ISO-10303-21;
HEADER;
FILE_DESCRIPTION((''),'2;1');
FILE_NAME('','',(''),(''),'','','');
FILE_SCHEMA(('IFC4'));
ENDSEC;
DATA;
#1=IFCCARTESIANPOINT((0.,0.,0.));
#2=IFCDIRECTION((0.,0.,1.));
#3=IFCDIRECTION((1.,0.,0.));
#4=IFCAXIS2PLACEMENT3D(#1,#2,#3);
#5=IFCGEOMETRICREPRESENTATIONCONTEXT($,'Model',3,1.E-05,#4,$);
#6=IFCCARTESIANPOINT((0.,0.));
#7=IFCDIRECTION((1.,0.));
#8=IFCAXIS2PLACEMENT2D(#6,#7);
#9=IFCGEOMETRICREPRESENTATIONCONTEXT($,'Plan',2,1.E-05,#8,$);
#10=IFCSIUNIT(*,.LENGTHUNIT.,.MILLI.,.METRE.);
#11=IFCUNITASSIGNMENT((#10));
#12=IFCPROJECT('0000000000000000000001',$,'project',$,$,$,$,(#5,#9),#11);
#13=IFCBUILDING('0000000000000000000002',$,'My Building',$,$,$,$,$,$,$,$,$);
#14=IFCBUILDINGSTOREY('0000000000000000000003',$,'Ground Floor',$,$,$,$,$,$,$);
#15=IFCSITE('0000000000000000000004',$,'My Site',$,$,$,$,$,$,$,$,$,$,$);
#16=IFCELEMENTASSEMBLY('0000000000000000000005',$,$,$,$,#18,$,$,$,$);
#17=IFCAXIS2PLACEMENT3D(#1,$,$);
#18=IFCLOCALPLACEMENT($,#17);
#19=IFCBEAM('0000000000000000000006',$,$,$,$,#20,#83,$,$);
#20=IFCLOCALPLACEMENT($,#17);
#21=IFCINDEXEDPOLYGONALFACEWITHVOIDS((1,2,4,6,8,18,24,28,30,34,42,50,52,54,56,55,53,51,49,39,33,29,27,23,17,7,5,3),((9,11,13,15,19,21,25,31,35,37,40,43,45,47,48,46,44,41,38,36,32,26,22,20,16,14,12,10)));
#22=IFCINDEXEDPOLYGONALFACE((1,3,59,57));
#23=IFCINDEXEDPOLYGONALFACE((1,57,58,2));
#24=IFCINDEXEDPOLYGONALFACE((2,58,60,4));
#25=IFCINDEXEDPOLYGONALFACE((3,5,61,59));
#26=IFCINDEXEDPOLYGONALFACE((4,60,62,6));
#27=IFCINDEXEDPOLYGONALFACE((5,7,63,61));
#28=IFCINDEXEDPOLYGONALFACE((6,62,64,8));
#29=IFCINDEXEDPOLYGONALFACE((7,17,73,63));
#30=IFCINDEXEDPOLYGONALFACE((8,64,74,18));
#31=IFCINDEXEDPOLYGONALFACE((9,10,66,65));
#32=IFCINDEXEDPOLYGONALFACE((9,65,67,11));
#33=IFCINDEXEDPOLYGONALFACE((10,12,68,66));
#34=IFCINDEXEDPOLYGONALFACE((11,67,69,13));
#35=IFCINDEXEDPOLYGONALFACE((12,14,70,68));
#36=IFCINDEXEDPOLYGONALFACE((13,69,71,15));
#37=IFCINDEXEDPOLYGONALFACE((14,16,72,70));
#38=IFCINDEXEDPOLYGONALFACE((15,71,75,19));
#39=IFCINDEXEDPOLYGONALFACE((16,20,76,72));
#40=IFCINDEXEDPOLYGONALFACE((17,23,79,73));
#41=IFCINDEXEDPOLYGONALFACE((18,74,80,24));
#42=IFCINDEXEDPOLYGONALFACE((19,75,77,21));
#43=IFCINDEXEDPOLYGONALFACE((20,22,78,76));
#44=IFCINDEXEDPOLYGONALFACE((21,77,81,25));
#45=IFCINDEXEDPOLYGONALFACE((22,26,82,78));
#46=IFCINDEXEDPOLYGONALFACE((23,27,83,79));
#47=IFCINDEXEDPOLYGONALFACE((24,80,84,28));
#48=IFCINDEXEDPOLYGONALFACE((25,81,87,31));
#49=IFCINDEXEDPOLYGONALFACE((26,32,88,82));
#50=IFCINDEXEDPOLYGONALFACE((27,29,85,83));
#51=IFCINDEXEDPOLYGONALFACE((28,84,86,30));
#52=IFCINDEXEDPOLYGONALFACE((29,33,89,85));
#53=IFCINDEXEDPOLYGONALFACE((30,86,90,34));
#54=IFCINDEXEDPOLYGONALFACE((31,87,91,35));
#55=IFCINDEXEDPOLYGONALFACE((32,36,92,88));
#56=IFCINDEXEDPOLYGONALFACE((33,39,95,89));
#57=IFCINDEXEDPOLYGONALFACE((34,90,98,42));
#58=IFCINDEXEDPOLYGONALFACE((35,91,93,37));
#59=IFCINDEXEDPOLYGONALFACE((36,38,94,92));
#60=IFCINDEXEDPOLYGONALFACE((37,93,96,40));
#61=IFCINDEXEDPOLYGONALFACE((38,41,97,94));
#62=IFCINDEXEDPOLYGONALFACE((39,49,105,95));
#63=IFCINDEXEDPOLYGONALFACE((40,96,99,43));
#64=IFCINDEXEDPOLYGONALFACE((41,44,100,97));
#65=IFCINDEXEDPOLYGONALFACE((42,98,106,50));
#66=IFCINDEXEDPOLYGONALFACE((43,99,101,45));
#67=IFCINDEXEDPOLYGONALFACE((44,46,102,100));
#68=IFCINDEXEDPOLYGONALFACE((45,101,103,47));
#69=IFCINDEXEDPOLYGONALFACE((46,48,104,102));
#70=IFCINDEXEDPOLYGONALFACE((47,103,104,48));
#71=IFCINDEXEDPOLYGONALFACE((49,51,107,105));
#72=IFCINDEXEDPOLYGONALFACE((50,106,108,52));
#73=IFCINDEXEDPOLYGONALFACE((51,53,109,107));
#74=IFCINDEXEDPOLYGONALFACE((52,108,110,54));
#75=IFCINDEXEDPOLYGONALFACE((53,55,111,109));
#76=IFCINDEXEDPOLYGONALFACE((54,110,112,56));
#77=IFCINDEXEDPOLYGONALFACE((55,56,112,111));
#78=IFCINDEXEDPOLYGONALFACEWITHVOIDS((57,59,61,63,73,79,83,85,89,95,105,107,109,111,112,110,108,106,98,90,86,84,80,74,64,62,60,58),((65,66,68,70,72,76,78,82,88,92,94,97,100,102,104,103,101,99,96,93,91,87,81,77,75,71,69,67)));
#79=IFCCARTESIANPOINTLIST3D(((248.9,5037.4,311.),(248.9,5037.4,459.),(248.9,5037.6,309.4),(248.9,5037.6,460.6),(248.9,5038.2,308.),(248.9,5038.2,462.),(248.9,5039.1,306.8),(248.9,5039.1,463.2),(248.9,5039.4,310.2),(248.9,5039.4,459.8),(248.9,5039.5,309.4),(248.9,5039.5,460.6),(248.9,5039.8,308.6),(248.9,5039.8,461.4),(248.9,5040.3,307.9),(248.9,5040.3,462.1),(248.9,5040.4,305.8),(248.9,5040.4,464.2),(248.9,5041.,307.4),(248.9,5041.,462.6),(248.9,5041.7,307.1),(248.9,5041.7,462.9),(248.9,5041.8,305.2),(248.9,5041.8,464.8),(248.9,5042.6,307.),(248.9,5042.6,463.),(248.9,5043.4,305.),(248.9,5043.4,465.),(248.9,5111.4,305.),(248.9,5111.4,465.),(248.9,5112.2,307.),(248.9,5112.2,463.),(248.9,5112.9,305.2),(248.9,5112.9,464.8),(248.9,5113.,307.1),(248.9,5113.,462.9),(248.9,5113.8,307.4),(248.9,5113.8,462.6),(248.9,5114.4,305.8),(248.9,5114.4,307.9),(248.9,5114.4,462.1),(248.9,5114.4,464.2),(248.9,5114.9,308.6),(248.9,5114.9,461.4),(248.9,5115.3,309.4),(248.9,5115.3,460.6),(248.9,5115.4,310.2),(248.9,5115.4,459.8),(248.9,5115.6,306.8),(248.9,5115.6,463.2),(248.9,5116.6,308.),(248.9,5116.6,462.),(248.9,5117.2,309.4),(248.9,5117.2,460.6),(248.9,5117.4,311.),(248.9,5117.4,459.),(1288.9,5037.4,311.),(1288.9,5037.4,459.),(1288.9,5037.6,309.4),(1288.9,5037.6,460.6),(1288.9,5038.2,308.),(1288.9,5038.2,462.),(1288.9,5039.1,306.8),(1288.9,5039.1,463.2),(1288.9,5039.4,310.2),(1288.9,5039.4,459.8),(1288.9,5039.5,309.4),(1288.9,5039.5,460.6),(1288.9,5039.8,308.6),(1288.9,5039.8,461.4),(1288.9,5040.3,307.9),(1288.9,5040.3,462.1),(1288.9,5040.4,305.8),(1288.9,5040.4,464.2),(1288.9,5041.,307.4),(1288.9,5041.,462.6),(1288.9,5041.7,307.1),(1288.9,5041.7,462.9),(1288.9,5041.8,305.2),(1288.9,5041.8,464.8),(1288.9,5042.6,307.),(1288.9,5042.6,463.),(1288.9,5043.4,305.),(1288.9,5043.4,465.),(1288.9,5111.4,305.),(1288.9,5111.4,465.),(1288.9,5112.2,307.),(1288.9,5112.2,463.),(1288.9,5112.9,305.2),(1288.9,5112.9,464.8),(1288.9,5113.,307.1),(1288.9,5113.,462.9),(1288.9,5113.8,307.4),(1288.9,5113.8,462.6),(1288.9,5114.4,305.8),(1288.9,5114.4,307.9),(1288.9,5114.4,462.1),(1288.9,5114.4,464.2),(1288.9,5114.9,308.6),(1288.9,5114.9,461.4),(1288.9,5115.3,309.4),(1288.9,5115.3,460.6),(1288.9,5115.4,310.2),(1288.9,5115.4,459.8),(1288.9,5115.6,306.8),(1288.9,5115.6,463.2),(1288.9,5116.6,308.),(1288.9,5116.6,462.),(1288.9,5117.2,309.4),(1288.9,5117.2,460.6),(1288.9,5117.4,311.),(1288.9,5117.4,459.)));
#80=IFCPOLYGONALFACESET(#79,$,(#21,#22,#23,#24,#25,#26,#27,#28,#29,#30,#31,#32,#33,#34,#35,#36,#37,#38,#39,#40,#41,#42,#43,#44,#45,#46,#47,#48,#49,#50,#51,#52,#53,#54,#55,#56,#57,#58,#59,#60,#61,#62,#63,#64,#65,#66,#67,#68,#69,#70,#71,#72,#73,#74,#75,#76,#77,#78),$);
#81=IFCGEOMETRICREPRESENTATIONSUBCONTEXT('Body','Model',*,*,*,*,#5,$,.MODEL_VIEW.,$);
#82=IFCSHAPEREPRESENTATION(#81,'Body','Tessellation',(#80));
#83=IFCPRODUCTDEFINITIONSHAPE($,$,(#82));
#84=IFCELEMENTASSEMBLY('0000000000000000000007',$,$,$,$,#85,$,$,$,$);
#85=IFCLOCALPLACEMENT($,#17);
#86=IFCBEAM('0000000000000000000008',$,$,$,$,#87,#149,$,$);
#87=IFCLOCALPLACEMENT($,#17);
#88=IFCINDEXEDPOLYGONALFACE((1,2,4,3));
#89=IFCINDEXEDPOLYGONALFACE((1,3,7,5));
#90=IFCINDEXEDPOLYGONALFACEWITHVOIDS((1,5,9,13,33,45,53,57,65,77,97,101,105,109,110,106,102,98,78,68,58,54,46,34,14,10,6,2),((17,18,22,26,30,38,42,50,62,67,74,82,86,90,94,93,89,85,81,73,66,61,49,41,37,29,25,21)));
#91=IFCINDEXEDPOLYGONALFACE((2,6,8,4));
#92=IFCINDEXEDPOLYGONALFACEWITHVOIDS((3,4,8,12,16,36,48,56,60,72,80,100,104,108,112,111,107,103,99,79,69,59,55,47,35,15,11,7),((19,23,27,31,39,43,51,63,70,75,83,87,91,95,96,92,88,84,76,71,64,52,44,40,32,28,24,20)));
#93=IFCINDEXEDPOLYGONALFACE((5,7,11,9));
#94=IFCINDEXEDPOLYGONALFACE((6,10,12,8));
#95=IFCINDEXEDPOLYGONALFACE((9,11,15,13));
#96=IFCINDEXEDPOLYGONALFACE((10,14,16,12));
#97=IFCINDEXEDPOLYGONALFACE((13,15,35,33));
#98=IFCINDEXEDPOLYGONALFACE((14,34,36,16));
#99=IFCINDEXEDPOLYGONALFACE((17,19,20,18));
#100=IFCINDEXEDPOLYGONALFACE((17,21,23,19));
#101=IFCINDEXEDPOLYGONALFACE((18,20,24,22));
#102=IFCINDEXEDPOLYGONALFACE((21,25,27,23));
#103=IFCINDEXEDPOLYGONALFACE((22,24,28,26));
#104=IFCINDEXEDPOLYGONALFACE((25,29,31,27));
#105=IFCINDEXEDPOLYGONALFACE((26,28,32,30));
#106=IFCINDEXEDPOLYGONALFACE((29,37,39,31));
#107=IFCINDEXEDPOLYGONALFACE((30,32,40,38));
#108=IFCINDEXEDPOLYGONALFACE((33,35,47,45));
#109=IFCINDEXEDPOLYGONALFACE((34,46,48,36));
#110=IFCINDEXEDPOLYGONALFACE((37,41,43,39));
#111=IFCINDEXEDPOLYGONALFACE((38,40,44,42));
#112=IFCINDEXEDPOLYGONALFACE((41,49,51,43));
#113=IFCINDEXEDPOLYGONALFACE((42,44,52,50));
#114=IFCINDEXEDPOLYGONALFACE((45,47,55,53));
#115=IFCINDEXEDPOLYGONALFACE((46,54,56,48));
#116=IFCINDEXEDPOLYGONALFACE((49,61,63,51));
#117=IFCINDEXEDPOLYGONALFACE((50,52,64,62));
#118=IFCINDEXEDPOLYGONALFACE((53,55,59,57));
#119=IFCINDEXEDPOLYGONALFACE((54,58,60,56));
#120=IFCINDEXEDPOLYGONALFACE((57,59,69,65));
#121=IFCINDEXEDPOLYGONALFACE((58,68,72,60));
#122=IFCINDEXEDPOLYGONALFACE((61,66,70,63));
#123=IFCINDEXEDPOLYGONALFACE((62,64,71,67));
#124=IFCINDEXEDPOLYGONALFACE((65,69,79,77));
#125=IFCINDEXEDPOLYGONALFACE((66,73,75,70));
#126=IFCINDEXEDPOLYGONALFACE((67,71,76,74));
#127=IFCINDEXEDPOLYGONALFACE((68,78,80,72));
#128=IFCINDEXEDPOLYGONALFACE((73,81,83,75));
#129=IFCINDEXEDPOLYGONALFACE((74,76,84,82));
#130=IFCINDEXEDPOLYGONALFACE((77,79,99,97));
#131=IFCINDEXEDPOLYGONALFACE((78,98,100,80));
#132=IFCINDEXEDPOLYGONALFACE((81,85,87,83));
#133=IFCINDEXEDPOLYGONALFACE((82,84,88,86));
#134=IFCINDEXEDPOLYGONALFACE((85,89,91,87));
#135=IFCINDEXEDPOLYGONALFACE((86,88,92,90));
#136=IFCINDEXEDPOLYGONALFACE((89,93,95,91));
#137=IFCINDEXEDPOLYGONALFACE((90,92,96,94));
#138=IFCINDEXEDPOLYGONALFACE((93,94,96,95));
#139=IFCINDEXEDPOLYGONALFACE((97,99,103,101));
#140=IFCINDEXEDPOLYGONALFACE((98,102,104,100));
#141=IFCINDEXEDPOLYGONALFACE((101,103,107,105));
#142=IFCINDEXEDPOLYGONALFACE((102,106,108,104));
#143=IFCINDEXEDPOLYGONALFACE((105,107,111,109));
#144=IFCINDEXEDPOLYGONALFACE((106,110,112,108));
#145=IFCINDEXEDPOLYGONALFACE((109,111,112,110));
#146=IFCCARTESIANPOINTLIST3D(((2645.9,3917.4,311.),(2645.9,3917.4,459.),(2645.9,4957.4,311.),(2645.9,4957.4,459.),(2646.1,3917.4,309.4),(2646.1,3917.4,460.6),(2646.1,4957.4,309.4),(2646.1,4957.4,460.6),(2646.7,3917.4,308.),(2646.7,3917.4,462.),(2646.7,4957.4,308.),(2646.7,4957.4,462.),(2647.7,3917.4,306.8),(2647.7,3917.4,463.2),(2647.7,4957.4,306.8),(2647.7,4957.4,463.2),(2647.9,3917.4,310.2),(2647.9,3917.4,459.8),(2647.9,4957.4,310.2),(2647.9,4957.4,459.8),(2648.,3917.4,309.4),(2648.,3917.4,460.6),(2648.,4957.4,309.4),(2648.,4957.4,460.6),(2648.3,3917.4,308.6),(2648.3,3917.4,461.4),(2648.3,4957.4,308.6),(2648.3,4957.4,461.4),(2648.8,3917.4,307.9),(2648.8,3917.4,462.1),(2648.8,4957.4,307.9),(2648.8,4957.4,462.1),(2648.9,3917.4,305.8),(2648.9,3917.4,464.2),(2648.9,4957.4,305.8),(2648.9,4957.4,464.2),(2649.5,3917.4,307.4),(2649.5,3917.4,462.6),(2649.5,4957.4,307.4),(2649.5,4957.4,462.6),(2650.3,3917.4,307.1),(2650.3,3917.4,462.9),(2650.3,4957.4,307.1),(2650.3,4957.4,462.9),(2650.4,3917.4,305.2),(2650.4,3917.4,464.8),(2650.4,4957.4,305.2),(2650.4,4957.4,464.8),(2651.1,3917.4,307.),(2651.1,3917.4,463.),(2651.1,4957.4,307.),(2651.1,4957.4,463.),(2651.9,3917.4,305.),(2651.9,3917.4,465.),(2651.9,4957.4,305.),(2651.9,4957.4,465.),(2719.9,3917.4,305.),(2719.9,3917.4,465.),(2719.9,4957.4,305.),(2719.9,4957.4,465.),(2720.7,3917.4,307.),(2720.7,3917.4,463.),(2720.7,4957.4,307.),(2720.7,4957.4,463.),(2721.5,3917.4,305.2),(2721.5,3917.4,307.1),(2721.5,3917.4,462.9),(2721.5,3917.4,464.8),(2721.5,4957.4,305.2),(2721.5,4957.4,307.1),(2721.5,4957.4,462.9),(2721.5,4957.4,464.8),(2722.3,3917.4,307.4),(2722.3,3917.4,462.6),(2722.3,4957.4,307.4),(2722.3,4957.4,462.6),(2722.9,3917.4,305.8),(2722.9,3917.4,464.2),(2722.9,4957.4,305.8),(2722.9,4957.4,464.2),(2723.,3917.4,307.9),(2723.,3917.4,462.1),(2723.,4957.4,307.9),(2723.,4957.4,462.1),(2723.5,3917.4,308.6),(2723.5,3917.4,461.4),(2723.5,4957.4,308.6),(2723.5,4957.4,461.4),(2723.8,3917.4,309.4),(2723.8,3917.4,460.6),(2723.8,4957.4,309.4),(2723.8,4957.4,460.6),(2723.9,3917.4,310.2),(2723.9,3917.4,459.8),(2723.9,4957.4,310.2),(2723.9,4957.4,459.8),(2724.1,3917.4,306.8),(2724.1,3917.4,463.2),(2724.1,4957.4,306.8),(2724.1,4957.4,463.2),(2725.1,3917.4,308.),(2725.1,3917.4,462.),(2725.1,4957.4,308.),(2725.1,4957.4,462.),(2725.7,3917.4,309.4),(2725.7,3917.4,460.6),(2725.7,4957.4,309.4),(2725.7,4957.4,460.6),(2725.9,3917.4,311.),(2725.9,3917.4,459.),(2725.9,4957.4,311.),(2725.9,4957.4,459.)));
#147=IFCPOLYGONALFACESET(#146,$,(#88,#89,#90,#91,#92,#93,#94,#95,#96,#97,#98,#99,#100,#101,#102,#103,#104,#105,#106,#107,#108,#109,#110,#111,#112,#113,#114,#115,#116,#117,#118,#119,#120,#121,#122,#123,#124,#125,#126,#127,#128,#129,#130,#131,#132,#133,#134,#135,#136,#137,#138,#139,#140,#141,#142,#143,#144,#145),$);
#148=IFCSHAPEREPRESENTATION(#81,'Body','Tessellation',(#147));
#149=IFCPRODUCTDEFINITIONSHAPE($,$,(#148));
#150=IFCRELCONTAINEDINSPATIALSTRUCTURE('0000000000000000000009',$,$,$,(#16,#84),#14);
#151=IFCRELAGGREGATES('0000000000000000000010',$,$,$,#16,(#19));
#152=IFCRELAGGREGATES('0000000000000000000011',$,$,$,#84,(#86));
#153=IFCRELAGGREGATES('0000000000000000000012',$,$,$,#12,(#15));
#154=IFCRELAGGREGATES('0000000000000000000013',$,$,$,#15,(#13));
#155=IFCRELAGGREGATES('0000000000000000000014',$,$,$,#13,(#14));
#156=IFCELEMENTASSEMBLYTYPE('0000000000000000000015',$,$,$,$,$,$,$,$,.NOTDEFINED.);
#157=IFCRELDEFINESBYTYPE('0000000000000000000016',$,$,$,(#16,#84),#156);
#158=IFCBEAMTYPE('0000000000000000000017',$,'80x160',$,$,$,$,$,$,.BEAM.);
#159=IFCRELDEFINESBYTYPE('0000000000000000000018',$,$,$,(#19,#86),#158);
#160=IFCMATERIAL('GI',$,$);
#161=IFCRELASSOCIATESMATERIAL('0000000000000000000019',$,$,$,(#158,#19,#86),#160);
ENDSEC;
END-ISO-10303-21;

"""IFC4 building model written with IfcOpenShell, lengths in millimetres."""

from ifc_helpers import new_model, si_unit, frame, origin_with_axes, origin_2d_with_axis, place, context, subcontext, project, spatial, hollow_rectangle, extrude, material, material_profile, profile_set, profile_usage, type_object, element, aggregate, save


model = new_model("IFC4")

# Units and contexts
model_context = context("Model", 3, precision=1e-05, world=origin_with_axes())
plan_context = context("Plan", 2, precision=1e-05, world=origin_2d_with_axis())
body_context = subcontext(model_context, "Body", "Model", "MODEL_VIEW")
ifc_project = project(units=[si_unit("LENGTHUNIT", "METRE", prefix="MILLI")], contexts=[model_context, plan_context])

# Site, building, storey
site = spatial("IfcSite", under=ifc_project, Name="My Site")
building = spatial("IfcBuilding", under=site, Name="My Building")
storey = spatial("IfcBuildingStorey", under=building, Name="Ground Floor")

# Shared definitions
ifc_material = material(Name="GI")

# Element assemblies, beams
element_assembly_type_1 = type_object("IfcElementAssemblyType", PredefinedType="NOTDEFINED")
ifc_material_profile_1 = material_profile(ifc_material, hollow_rectangle(XDim=80.0, YDim=160.0, WallThickness=2.0, InnerFilletRadius=3.2, OuterFilletRadius=6.0))
ifc_profile_set_1 = profile_set([ifc_material_profile_1], Name="80x160 GI Rectangular Hollow")
beam_type = type_object("IfcBeamType", Name="80x160", PredefinedType="BEAM", material=ifc_profile_set_1)
assembly_1_placement = place(None, frame((168.9, 5077.4, 385.0), z_axis=(1.0, 0.0, 0.0), x_axis=(0.0, 1.0, 0.0)))
assembly_1 = element("IfcElementAssembly", 1, at=assembly_1_placement, inside=storey, type_object=element_assembly_type_1)
ifc_profile_usage_1 = profile_usage(ifc_profile_set_1)
beam_1_placement = place(assembly_1_placement, frame((0.0, 0.0, 80.0), z_axis=(0.0, 0.0, 1.0), x_axis=(1.0, 0.0, 0.0)))
beam_1 = element("IfcBeam", 2, at=beam_1_placement, type_object=beam_type, material=ifc_profile_usage_1, context=body_context, shape_type="SweptSolid", body=[
    extrude(hollow_rectangle(XDim=80.0, YDim=160.0, WallThickness=2.0, InnerFilletRadius=3.2, OuterFilletRadius=6.0), origin_with_axes(), (0.0, 0.0, 1.0), 1040.0),
])
aggregate(assembly_1, [beam_1])
assembly_2_placement = place(None, frame((2685.9, 3837.4, 385.0), z_axis=(0.0, 1.0, 0.0), x_axis=(1.0, 0.0, 0.0)))
assembly_2 = element("IfcElementAssembly", 3, at=assembly_2_placement, inside=storey, type_object=element_assembly_type_1)
ifc_profile_usage_2 = profile_usage(ifc_profile_set_1)
beam_2_placement = place(assembly_2_placement, frame((0.0, 0.0, 80.0), z_axis=(0.0, 0.0, 1.0), x_axis=(1.0, 0.0, 0.0)))
beam_2 = element("IfcBeam", 4, at=beam_2_placement, type_object=beam_type, material=ifc_profile_usage_2, context=body_context, shape_type="SweptSolid", body=[
    extrude(hollow_rectangle(XDim=80.0, YDim=160.0, WallThickness=2.0, InnerFilletRadius=3.2, OuterFilletRadius=6.0), origin_with_axes(), (0.0, 0.0, 1.0), 1040.0),
])
aggregate(assembly_2, [beam_2])

save(model, "model.ifc")
